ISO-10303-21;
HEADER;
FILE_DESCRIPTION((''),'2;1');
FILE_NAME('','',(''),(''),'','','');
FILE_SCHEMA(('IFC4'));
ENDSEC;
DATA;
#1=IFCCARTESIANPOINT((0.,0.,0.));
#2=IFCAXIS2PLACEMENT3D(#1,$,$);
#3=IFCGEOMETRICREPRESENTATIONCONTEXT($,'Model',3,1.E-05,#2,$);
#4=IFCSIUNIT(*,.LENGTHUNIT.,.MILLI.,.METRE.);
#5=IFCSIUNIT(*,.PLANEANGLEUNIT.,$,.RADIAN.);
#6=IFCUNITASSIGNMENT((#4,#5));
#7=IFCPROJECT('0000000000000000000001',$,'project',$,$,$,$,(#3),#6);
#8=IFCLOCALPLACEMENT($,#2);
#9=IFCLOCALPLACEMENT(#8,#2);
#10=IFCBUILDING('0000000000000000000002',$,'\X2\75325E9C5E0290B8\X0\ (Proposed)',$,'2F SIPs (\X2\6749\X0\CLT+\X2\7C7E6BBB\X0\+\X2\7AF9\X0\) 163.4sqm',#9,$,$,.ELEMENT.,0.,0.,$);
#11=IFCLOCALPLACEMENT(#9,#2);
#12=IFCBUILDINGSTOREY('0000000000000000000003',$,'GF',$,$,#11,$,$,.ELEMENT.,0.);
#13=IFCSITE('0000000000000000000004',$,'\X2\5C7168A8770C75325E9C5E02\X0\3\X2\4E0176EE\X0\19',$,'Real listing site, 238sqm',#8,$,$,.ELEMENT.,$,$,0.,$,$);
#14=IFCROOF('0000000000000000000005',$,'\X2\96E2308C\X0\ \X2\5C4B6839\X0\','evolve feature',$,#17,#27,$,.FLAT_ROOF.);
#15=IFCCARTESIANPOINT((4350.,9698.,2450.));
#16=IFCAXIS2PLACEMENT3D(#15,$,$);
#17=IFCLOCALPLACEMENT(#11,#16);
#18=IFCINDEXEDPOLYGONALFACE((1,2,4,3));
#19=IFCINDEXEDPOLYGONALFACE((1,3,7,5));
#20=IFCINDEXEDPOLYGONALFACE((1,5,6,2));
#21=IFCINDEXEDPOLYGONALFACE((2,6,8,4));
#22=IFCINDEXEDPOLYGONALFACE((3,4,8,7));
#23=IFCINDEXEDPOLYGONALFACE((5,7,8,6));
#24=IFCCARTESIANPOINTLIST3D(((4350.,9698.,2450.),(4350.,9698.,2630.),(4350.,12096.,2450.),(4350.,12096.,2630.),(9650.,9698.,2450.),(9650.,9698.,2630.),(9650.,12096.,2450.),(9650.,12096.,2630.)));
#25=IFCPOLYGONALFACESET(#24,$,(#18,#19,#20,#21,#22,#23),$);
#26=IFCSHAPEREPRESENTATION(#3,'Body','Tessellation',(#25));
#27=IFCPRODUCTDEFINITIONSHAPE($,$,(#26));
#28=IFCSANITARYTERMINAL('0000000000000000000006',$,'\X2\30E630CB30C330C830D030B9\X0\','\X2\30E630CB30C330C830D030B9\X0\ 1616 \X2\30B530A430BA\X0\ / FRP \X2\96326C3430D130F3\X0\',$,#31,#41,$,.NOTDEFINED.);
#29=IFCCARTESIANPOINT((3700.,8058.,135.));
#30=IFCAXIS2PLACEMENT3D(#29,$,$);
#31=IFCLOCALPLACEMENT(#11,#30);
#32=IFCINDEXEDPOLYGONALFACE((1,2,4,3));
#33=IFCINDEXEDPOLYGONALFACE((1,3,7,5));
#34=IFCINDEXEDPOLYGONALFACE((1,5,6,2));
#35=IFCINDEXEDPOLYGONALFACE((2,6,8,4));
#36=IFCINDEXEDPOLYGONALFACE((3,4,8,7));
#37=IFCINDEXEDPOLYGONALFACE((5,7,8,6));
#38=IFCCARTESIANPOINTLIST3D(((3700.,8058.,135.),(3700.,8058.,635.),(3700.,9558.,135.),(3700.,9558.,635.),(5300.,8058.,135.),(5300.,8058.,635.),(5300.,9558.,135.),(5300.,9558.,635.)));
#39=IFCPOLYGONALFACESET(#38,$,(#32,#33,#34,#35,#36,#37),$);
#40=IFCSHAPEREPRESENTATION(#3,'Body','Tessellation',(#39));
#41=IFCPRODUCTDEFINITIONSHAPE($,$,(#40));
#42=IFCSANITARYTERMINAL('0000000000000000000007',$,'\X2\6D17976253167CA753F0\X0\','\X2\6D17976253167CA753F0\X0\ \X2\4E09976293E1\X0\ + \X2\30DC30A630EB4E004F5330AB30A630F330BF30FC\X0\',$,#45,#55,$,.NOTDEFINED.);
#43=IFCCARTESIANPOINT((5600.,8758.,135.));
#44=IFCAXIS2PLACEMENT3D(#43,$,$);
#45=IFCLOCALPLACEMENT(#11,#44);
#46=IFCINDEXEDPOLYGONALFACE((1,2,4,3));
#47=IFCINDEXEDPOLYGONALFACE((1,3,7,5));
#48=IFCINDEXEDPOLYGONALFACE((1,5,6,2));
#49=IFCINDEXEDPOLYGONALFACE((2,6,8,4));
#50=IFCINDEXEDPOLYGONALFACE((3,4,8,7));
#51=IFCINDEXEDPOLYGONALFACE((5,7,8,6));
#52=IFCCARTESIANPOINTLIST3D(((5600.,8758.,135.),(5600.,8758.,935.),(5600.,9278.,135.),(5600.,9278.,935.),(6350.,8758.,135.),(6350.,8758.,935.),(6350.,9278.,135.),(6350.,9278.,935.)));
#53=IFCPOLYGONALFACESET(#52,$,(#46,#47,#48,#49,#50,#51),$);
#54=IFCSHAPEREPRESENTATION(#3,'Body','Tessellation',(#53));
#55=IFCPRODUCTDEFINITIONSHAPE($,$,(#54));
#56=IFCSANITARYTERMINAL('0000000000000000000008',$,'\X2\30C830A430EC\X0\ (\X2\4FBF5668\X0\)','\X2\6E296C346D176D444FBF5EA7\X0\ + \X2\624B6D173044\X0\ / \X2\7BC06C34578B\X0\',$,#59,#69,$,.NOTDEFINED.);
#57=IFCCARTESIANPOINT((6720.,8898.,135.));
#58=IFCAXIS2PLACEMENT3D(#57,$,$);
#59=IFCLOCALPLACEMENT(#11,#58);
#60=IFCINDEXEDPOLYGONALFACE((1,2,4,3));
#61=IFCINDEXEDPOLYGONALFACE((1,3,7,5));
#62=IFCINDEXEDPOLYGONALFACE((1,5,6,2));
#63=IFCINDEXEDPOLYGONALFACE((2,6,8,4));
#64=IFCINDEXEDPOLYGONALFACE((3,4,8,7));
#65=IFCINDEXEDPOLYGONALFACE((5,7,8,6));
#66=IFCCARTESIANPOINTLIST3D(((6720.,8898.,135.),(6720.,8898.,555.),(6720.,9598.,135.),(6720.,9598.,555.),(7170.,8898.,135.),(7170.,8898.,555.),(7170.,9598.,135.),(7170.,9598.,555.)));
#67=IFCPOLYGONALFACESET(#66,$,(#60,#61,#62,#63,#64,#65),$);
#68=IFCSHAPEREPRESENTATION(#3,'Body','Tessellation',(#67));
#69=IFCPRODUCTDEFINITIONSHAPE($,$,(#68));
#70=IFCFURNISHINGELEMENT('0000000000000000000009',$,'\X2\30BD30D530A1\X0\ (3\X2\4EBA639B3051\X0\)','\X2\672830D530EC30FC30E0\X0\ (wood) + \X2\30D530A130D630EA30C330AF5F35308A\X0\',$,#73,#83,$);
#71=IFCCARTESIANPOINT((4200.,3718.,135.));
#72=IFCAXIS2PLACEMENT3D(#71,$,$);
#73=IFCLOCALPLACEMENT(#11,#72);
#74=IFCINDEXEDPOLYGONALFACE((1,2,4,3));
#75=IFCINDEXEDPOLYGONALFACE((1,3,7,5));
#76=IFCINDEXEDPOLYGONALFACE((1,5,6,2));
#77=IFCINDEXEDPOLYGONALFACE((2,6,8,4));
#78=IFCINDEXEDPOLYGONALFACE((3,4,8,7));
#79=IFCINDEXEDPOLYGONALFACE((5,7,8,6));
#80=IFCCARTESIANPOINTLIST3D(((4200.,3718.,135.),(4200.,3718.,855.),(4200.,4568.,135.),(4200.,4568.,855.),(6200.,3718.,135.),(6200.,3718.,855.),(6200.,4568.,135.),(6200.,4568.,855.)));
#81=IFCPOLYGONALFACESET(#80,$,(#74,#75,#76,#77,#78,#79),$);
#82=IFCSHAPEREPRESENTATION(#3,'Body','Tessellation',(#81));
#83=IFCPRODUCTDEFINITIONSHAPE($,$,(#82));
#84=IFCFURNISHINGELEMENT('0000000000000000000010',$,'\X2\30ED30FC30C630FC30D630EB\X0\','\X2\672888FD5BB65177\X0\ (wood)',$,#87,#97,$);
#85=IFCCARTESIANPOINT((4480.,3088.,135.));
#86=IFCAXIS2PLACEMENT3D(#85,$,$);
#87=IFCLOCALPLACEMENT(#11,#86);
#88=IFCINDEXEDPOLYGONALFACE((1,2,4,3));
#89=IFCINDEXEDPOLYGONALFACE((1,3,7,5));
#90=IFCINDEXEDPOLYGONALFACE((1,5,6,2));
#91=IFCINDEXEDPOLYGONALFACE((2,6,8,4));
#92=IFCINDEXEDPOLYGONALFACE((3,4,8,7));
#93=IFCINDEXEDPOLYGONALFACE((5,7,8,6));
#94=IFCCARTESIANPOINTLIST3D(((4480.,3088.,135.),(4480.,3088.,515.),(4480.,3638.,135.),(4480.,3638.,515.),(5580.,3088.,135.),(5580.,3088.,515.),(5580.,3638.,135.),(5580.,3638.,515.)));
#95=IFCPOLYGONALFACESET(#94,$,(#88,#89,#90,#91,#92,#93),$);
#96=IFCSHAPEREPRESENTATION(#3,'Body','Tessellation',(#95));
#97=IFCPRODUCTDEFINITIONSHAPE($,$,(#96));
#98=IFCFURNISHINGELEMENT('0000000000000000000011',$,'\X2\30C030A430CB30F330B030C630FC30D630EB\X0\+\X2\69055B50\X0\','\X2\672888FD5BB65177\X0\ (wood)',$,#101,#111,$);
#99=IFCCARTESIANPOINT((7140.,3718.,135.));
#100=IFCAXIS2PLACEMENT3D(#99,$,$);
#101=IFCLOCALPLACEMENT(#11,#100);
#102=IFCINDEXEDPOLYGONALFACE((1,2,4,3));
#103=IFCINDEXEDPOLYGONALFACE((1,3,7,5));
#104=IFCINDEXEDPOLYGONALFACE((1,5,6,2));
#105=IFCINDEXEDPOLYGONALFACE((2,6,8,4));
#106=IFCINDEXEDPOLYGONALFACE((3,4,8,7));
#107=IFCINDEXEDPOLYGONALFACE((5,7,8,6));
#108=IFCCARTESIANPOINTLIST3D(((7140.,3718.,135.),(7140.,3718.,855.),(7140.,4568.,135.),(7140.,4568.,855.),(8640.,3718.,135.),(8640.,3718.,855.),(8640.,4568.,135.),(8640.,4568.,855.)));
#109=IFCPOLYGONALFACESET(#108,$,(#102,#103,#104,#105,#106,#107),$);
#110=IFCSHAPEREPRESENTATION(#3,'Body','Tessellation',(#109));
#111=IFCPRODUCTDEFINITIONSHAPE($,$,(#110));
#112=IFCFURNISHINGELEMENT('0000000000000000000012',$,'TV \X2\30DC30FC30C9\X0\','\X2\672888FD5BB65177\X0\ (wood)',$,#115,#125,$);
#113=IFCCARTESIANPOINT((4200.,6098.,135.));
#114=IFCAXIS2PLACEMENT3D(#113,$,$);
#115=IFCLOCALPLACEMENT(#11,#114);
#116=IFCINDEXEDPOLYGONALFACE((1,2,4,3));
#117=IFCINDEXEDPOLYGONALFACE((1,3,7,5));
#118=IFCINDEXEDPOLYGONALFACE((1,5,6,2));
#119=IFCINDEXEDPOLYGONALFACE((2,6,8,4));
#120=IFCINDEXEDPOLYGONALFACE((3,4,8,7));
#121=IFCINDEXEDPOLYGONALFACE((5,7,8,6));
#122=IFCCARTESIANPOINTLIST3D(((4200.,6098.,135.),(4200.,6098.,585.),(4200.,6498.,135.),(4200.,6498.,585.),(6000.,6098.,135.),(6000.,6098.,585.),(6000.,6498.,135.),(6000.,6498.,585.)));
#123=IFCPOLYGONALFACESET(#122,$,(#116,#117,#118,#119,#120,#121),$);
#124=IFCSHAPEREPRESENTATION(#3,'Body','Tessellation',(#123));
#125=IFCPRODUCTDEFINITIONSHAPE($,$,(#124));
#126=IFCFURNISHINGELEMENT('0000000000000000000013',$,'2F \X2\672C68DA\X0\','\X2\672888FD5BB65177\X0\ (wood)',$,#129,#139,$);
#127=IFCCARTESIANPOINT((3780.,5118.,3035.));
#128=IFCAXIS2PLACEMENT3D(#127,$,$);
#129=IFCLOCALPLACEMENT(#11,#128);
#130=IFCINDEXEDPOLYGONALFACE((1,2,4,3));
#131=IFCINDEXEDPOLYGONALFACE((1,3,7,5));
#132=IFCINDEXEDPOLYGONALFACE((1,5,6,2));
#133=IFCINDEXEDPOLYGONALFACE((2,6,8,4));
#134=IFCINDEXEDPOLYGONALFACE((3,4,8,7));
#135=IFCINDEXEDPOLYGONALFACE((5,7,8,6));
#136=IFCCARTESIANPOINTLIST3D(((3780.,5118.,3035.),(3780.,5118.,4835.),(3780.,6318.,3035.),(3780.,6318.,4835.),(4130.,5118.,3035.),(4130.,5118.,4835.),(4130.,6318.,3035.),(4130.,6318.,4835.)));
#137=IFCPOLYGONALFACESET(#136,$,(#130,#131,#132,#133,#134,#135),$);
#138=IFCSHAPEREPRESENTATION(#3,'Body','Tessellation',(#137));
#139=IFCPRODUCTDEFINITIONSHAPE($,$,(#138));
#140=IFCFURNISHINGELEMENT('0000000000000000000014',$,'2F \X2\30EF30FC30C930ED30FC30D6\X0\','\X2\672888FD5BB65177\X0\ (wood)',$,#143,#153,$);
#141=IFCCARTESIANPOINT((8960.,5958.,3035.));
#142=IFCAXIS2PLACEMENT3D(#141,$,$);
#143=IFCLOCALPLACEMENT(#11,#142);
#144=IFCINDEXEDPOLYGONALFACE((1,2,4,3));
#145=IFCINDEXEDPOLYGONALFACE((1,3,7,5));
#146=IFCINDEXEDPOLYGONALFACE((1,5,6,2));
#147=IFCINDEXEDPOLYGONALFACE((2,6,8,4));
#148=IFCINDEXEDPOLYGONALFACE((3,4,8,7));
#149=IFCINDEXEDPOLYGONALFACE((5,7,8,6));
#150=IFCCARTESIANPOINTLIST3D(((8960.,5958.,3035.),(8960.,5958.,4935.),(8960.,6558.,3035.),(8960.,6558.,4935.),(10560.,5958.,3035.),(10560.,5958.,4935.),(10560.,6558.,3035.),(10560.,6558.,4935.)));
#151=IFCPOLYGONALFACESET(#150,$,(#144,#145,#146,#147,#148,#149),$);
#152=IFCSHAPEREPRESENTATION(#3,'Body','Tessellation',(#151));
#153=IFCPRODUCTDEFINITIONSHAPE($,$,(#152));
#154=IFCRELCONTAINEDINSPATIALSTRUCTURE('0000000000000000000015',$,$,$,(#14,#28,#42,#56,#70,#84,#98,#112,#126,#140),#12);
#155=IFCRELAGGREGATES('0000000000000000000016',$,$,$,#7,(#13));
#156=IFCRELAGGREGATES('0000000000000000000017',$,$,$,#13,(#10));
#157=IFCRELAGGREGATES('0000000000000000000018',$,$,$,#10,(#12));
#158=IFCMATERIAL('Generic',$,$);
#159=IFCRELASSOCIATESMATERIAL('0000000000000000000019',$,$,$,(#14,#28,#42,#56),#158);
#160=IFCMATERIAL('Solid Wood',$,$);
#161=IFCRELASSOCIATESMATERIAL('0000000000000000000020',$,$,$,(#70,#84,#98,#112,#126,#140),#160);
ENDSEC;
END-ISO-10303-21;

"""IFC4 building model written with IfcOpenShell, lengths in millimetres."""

from ifc_helpers import new_model, si_unit, frame, frame_2d, origin, place, context, project, spatial, rectangle, extrude, material, element, save


model = new_model("IFC4")

# Units and contexts
model_context = context("Model", 3, precision=1e-05, world=origin())
ifc_project = project(units=[si_unit("LENGTHUNIT", "METRE", prefix="MILLI"), si_unit("PLANEANGLEUNIT", "RADIAN")], contexts=[model_context])

# Site, building, storey
site_placement = place(None, origin())
site = spatial("IfcSite", under=ifc_project, at=site_placement, Name="山梨県甲府市3丁目19", ObjectType="Real listing site, 238sqm", CompositionType="ELEMENT", RefElevation=0.0)
building_placement = place(site_placement, origin())
building = spatial("IfcBuilding", under=site, at=building_placement, Name="甲府市邸 (Proposed)", ObjectType="2F SIPs (杉CLT+籾殻+竹) 163.4sqm", CompositionType="ELEMENT", ElevationOfRefHeight=0.0, ElevationOfTerrain=0.0)
storey_placement = place(building_placement, origin())
storey = spatial("IfcBuildingStorey", under=building, at=storey_placement, Name="GF", CompositionType="ELEMENT", Elevation=0.0)

# Shared definitions
ifc_material_1 = material(Name="Generic")

# Shared definitions
ifc_material_2 = material(Name="Solid Wood")

# Roof
roof_placement = place(storey_placement, frame((4350.0, 9698.0, 2450.0)))
element("IfcRoof", 1, at=roof_placement, inside=storey, material=ifc_material_1, Name="離れ 屋根", Description="evolve feature", PredefinedType="FLAT_ROOF", context=model_context, shape_type="SweptSolid", body=[
    extrude(rectangle(XDim=5300.0, YDim=2398.0, at=frame_2d((2650.0, 1199.0))), frame((4350.0, 9698.0, 2450.0)), (0.0, 0.0, 1.0), 180.0),
])

# Sanitary terminals
sanitary_terminal_1_placement = place(storey_placement, frame((3700.0, 8058.0, 135.0)))
element("IfcSanitaryTerminal", 2, at=sanitary_terminal_1_placement, inside=storey, material=ifc_material_1, Name="ユニットバス", Description="ユニットバス 1616 サイズ / FRP 防水パン", PredefinedType="NOTDEFINED", context=model_context, shape_type="SweptSolid", body=[
    extrude(rectangle(XDim=1600.0, YDim=1500.0, at=frame_2d((800.0, 750.0))), frame((3700.0, 8058.0, 135.0)), (0.0, 0.0, 1.0), 500.0),
])
sanitary_terminal_2_placement = place(storey_placement, frame((5600.0, 8758.0, 135.0)))
element("IfcSanitaryTerminal", 3, at=sanitary_terminal_2_placement, inside=storey, material=ifc_material_1, Name="洗面化粧台", Description="洗面化粧台 三面鏡 + ボウル一体カウンター", PredefinedType="NOTDEFINED", context=model_context, shape_type="SweptSolid", body=[
    extrude(rectangle(XDim=750.0, YDim=520.0, at=frame_2d((375.0, 260.0))), frame((5600.0, 8758.0, 135.0)), (0.0, 0.0, 1.0), 800.0),
])
sanitary_terminal_3_placement = place(storey_placement, frame((6720.0, 8898.0, 135.0)))
element("IfcSanitaryTerminal", 4, at=sanitary_terminal_3_placement, inside=storey, material=ifc_material_1, Name="トイレ (便器)", Description="温水洗浄便座 + 手洗い / 節水型", PredefinedType="NOTDEFINED", context=model_context, shape_type="SweptSolid", body=[
    extrude(rectangle(XDim=450.0, YDim=700.0, at=frame_2d((225.0, 350.0))), frame((6720.0, 8898.0, 135.0)), (0.0, 0.0, 1.0), 420.0),
])

# Furnishing elements
furnishing_1_placement = place(storey_placement, frame((4200.0, 3718.0, 135.0)))
element("IfcFurnishingElement", 5, at=furnishing_1_placement, inside=storey, material=ifc_material_2, Name="ソファ (3人掛け)", Description="木フレーム (wood) + ファブリック張り", context=model_context, shape_type="SweptSolid", body=[
    extrude(rectangle(XDim=2000.0, YDim=850.0, at=frame_2d((1000.0, 425.0))), frame((4200.0, 3718.0, 135.0)), (0.0, 0.0, 1.0), 720.0),
])
furnishing_2_placement = place(storey_placement, frame((4480.0, 3088.0, 135.0)))
element("IfcFurnishingElement", 6, at=furnishing_2_placement, inside=storey, material=ifc_material_2, Name="ローテーブル", Description="木製家具 (wood)", context=model_context, shape_type="SweptSolid", body=[
    extrude(rectangle(XDim=1100.0, YDim=550.0, at=frame_2d((550.0, 275.0))), frame((4480.0, 3088.0, 135.0)), (0.0, 0.0, 1.0), 380.0),
])
furnishing_3_placement = place(storey_placement, frame((7140.0, 3718.0, 135.0)))
element("IfcFurnishingElement", 7, at=furnishing_3_placement, inside=storey, material=ifc_material_2, Name="ダイニングテーブル+椅子", Description="木製家具 (wood)", context=model_context, shape_type="SweptSolid", body=[
    extrude(rectangle(XDim=1500.0, YDim=850.0, at=frame_2d((750.0, 425.0))), frame((7140.0, 3718.0, 135.0)), (0.0, 0.0, 1.0), 720.0),
])
furnishing_4_placement = place(storey_placement, frame((4200.0, 6098.0, 135.0)))
element("IfcFurnishingElement", 8, at=furnishing_4_placement, inside=storey, material=ifc_material_2, Name="TV ボード", Description="木製家具 (wood)", context=model_context, shape_type="SweptSolid", body=[
    extrude(rectangle(XDim=1800.0, YDim=400.0, at=frame_2d((900.0, 200.0))), frame((4200.0, 6098.0, 135.0)), (0.0, 0.0, 1.0), 450.0),
])
furnishing_5_placement = place(storey_placement, frame((3780.0, 5118.0, 3035.0)))
element("IfcFurnishingElement", 9, at=furnishing_5_placement, inside=storey, material=ifc_material_2, Name="2F 本棚", Description="木製家具 (wood)", context=model_context, shape_type="SweptSolid", body=[
    extrude(rectangle(XDim=350.0, YDim=1200.0, at=frame_2d((175.0, 600.0))), frame((3780.0, 5118.0, 3035.0)), (0.0, 0.0, 1.0), 1800.0),
])
furnishing_6_placement = place(storey_placement, frame((8960.0, 5958.0, 3035.0)))
element("IfcFurnishingElement", 10, at=furnishing_6_placement, inside=storey, material=ifc_material_2, Name="2F ワードローブ", Description="木製家具 (wood)", context=model_context, shape_type="SweptSolid", body=[
    extrude(rectangle(XDim=1600.0, YDim=600.0, at=frame_2d((800.0, 300.0))), frame((8960.0, 5958.0, 3035.0)), (0.0, 0.0, 1.0), 1900.0),
])

save(model, "model.ifc")
